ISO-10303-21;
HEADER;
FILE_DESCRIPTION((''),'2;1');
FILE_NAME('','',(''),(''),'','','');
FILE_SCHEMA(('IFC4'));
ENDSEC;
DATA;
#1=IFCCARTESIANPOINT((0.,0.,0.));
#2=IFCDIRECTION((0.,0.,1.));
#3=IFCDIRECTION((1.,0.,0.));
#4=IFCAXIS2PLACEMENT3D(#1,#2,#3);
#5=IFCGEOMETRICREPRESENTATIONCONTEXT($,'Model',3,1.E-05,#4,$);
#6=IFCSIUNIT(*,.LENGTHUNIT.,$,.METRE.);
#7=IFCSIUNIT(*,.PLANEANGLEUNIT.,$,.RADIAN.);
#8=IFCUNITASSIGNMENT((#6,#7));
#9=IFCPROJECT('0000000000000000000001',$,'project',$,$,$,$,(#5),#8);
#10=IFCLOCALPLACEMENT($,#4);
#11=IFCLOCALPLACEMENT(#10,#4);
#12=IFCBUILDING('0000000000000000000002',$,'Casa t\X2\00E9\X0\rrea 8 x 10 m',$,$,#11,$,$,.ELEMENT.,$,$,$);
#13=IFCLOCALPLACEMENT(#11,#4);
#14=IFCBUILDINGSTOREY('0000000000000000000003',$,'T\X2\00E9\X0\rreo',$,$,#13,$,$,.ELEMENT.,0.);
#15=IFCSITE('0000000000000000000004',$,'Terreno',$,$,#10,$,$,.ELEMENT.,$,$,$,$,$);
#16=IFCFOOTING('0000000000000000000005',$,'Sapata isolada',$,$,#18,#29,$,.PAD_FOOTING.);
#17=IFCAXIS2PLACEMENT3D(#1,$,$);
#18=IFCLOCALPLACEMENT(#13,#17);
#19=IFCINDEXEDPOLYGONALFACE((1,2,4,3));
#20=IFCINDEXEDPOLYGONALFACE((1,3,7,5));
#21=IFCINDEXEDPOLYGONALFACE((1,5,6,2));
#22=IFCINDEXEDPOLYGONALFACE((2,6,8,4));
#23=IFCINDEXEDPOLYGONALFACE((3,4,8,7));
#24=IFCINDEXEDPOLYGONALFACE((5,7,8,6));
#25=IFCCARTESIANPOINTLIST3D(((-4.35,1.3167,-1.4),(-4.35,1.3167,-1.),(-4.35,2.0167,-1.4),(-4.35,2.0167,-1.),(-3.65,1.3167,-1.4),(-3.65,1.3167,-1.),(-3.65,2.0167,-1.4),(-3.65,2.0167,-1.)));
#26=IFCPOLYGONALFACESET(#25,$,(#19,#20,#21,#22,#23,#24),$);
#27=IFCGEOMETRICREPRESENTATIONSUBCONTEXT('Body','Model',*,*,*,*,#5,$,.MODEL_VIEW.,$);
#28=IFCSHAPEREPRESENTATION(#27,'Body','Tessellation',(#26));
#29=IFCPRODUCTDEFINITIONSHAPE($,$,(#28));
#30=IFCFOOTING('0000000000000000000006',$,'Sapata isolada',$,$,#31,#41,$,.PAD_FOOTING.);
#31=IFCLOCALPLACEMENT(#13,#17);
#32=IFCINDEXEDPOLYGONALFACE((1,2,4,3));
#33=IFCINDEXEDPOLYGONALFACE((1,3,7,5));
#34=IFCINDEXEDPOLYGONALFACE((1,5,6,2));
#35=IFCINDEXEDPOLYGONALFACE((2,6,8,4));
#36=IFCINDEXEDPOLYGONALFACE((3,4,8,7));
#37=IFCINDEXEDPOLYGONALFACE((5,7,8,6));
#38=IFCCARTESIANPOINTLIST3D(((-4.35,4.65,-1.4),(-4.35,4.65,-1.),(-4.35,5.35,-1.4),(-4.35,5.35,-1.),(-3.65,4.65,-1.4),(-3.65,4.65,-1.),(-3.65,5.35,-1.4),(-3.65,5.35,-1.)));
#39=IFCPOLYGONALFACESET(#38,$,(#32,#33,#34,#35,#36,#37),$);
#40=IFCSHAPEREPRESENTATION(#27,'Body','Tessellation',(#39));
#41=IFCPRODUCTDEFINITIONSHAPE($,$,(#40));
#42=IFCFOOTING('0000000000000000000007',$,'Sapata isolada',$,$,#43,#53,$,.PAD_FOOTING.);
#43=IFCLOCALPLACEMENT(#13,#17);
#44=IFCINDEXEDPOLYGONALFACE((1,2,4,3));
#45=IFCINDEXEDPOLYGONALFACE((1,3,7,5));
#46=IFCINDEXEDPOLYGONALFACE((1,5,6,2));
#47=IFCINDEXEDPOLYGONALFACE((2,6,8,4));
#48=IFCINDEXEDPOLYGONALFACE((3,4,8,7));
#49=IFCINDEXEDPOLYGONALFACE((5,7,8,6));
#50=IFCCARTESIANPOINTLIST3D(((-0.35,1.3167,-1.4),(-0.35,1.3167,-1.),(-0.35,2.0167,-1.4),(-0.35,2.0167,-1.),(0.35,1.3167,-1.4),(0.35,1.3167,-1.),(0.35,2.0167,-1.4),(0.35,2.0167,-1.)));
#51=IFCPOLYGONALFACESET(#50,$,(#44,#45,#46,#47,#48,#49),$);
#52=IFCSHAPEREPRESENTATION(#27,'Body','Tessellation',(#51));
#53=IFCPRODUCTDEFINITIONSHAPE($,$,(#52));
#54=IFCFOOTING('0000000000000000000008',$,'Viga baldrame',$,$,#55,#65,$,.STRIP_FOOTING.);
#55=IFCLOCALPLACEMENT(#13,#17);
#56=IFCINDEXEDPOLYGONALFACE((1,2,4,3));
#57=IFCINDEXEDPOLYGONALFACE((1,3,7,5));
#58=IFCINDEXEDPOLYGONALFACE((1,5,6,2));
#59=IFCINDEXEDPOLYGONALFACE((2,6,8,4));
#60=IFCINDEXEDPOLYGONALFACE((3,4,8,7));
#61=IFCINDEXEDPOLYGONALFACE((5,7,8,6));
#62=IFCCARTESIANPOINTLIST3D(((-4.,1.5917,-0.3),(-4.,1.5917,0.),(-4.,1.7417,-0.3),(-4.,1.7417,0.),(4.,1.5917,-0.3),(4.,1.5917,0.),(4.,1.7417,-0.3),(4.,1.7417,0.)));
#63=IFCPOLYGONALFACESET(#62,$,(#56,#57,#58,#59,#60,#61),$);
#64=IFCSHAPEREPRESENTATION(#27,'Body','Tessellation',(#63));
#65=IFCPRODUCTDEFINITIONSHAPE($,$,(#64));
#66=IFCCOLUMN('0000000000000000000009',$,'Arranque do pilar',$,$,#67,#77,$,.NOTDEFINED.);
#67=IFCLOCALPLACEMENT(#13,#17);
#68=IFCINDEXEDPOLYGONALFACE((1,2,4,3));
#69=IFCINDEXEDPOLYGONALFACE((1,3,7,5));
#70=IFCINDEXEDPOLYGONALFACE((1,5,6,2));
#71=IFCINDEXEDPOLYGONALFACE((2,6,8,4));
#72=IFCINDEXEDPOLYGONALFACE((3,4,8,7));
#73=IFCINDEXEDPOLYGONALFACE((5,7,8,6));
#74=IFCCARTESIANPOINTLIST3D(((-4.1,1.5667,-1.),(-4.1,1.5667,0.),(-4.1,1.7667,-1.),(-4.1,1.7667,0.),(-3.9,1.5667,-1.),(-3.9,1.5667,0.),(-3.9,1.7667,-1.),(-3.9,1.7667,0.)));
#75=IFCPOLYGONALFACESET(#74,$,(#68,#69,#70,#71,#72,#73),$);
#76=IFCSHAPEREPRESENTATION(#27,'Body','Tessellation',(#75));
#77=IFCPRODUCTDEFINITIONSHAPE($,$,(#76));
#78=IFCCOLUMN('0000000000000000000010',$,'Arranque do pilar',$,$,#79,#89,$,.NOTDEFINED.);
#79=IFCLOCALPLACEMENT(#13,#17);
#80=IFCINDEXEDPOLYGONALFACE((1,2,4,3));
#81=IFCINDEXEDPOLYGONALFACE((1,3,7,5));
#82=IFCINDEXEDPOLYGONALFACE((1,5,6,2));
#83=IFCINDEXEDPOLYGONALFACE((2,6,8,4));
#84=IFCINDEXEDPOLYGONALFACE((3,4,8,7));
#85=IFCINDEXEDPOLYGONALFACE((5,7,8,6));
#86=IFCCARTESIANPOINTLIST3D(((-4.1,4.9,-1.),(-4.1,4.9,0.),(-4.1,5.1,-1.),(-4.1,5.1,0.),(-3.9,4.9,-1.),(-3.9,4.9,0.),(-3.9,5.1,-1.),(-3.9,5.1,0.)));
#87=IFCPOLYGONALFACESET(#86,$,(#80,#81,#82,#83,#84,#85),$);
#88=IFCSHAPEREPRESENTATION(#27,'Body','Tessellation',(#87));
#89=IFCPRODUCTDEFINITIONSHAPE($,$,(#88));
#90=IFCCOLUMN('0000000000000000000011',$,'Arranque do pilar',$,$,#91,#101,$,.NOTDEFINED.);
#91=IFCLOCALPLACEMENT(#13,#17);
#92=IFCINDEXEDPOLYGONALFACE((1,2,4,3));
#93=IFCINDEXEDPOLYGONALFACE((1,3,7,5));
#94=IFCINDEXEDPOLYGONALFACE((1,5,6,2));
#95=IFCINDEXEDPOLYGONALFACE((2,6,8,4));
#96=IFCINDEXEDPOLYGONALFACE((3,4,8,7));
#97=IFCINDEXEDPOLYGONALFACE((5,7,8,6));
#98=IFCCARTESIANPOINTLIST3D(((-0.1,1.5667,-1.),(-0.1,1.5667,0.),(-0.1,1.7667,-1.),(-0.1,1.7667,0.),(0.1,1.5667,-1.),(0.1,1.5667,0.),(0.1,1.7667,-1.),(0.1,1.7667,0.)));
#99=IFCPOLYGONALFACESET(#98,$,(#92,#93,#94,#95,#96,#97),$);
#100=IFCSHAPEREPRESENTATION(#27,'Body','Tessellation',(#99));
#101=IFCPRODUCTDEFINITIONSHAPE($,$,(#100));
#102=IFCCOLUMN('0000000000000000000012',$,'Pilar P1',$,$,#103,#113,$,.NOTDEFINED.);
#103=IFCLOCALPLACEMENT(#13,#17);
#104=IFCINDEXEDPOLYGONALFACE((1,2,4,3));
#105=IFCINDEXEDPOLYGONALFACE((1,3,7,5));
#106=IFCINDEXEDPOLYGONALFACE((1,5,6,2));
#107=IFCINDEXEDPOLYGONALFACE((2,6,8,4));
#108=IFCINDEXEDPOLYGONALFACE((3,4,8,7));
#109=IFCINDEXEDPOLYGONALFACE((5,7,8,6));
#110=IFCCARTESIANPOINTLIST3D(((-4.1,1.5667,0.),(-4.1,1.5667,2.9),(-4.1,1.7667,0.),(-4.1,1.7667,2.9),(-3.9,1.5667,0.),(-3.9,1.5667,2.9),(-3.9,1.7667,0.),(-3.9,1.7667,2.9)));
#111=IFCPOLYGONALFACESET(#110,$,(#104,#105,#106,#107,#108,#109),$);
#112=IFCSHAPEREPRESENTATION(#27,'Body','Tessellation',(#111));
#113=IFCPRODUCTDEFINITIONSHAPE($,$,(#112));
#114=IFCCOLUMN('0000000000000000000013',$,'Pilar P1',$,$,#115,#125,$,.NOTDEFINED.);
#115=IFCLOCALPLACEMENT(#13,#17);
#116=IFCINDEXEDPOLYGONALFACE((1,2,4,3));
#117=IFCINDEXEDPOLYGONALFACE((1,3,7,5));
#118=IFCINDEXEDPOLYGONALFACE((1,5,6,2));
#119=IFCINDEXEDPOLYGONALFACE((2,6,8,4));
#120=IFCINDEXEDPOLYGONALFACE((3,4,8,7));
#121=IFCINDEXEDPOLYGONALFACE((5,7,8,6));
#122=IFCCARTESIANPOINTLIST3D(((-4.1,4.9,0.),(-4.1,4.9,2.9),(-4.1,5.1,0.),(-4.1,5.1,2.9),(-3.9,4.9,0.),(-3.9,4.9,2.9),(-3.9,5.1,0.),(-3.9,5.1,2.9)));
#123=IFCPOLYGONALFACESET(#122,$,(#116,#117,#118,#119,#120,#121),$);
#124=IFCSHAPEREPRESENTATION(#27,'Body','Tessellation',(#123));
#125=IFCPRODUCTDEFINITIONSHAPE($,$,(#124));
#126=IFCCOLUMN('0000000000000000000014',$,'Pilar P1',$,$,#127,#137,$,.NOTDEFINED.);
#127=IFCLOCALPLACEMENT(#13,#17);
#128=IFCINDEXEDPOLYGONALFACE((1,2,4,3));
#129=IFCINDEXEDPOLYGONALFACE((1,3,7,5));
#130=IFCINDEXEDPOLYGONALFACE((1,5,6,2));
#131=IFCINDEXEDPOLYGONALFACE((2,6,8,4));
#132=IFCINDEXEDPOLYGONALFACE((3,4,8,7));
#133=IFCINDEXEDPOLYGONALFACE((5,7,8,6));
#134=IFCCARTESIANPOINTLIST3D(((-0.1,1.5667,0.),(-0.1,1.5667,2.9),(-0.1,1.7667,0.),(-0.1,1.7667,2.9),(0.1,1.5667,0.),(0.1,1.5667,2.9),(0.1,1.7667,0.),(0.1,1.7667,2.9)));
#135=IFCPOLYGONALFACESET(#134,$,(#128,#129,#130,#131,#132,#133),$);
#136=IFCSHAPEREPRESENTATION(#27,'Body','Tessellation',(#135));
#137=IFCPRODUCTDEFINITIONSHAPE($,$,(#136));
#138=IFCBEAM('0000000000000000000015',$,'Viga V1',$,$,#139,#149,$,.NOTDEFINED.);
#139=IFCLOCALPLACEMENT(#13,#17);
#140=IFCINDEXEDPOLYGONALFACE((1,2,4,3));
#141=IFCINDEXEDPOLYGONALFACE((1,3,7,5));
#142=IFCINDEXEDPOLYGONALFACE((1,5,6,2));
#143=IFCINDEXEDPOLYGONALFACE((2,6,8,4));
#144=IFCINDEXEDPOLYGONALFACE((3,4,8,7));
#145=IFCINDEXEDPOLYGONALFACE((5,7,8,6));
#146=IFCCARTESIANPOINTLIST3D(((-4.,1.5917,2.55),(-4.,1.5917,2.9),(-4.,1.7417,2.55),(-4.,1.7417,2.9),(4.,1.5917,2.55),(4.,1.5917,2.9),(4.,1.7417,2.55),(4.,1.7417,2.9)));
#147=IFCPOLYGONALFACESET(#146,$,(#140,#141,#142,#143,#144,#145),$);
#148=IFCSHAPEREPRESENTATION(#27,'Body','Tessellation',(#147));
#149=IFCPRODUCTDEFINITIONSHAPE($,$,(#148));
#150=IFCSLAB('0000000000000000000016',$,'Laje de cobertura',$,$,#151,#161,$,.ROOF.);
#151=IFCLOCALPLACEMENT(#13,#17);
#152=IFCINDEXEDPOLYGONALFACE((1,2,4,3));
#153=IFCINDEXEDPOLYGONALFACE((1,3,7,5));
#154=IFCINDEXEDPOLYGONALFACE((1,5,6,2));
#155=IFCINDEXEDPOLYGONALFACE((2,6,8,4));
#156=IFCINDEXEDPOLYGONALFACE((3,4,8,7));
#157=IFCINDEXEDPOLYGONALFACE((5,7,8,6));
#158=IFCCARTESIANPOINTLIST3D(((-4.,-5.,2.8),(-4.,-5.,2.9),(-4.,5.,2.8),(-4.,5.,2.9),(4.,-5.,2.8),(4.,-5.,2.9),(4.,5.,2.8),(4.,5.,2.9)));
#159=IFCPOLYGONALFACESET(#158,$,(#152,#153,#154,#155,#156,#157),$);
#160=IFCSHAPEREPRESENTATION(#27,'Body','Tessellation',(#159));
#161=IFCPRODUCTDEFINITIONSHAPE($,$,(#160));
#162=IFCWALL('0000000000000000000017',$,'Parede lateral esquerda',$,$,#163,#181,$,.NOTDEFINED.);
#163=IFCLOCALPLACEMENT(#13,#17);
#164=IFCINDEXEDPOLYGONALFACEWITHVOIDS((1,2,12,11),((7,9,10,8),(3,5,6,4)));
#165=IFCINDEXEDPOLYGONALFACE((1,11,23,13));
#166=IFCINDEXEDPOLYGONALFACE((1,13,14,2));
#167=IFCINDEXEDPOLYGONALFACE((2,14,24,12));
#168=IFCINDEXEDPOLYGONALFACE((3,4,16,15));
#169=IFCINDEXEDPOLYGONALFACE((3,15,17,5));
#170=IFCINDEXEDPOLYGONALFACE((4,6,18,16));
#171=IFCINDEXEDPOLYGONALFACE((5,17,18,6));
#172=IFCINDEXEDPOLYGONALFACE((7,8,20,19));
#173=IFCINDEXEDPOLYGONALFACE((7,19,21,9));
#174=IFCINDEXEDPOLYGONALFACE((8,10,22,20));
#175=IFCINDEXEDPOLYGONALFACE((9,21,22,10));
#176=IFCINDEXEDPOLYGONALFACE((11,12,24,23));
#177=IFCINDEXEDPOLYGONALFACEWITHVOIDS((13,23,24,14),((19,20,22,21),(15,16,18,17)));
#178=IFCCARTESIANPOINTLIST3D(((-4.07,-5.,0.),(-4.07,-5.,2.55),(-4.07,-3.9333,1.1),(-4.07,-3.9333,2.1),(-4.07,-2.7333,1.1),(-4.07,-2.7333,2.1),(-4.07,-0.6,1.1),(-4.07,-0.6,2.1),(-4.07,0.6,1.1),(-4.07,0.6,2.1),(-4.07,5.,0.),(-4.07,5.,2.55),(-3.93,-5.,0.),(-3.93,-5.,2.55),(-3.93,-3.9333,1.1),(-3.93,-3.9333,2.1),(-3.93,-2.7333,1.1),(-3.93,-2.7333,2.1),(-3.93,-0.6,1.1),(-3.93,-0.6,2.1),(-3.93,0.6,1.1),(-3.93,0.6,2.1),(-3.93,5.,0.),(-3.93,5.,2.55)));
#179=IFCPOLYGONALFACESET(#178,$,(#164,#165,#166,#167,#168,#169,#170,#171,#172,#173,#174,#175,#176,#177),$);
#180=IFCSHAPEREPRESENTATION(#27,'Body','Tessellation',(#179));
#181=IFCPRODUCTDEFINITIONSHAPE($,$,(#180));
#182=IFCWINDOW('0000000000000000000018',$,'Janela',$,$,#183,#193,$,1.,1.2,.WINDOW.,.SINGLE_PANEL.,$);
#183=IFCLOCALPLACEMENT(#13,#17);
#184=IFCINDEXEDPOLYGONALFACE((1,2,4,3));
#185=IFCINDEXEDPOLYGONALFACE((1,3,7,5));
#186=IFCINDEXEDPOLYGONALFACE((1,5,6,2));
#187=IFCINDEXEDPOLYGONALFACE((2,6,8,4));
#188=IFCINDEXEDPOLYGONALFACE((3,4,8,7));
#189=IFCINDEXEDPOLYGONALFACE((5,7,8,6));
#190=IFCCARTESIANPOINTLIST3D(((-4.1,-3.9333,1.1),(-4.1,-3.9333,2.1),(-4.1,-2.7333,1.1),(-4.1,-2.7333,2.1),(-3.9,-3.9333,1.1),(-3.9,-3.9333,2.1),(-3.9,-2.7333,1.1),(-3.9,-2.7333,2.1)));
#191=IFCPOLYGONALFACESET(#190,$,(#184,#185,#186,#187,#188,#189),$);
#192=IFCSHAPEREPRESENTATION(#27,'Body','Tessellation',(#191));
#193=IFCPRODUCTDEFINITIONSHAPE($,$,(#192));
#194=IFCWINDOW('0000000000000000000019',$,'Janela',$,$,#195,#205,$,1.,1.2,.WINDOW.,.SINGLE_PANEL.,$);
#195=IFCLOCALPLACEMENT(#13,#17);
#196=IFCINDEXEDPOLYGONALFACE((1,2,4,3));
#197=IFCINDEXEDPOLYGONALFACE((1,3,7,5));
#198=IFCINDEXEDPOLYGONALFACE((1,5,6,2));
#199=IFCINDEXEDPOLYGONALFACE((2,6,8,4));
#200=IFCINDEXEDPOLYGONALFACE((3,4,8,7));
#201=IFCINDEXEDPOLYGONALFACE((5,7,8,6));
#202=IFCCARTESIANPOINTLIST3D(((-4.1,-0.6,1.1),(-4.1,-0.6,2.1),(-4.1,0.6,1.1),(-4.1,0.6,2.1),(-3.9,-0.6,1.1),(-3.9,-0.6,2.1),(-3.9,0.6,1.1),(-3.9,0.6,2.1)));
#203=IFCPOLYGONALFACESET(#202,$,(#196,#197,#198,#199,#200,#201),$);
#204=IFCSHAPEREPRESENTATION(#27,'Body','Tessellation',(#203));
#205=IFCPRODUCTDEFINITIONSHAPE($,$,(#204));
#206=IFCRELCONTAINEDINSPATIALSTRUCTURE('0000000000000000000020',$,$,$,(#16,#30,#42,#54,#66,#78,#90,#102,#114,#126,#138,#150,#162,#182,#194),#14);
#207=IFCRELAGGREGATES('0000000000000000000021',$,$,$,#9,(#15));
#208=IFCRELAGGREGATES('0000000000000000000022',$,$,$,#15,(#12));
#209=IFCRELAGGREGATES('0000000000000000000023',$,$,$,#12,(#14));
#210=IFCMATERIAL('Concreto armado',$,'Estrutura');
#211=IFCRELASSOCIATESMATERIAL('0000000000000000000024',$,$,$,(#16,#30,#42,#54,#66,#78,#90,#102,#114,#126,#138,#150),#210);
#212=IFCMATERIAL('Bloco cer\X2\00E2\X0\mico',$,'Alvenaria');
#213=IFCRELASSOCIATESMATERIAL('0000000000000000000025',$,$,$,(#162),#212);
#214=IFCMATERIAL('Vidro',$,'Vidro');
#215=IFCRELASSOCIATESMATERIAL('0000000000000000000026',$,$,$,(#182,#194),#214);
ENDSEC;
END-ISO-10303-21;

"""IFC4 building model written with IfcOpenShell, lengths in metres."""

from ifc_helpers import new_model, si_unit, frame, origin_with_axes, origin_2d, place, context, subcontext, project, spatial, rectangle, extrude, material, element, fill, save


model = new_model("IFC4")

# Units and contexts
model_context = context("Model", 3, precision=1e-05, world=origin_with_axes())
body_context = subcontext(model_context, "Body", "Model", "MODEL_VIEW")
ifc_project = project(units=[si_unit("LENGTHUNIT", "METRE"), si_unit("PLANEANGLEUNIT", "RADIAN")], contexts=[model_context])

# Site, building, storey
site_placement = place(None, origin_with_axes())
site = spatial("IfcSite", under=ifc_project, at=site_placement, Name="Terreno", CompositionType="ELEMENT")
building_placement = place(site_placement, origin_with_axes())
building = spatial("IfcBuilding", under=site, at=building_placement, Name="Casa térrea 8 x 10 m", CompositionType="ELEMENT")
storey_placement = place(building_placement, origin_with_axes())
storey = spatial("IfcBuildingStorey", under=building, at=storey_placement, Name="Térreo", CompositionType="ELEMENT", Elevation=0.0)

# Footings
ifc_material_1 = material(Name="Concreto armado", Category="Estrutura")
for number, where, z_axis, x_axis, name in (
    (1, (-4.0, 1.6667, -1.4), (0.0, 0.0, 1.0), (1.0, 0.0, 0.0), "Sapata isolada"),
    (2, (-4.0, 5.0, -1.4), (0.0, 0.0, 1.0), (1.0, 0.0, 0.0), "Sapata isolada"),
    (3, (0.0, 1.6667, -1.4), (0.0, 0.0, 1.0), (1.0, 0.0, 0.0), "Sapata isolada"),
):
    element("IfcFooting", number, at=place(storey_placement, frame(where, z_axis=z_axis, x_axis=x_axis)), inside=storey, material=ifc_material_1, Name=name, PredefinedType="PAD_FOOTING", context=body_context, shape_type="SweptSolid", body=[
        extrude(rectangle(XDim=0.7, YDim=0.7, at=origin_2d()), None, (0.0, 0.0, 1.0), 0.4),
    ])
footing_placement = place(storey_placement, frame((0.0, 1.6667, -0.3), z_axis=(0.0, 0.0, 1.0), x_axis=(1.0, 0.0, 0.0)))
element("IfcFooting", 4, at=footing_placement, inside=storey, material=ifc_material_1, Name="Viga baldrame", PredefinedType="STRIP_FOOTING", context=body_context, shape_type="SweptSolid", body=[
    extrude(rectangle(XDim=8.0, YDim=0.15, at=origin_2d()), None, (0.0, 0.0, 1.0), 0.3),
])

# Columns
for number, where, z_axis, x_axis, name in (
    (5, (-4.0, 1.6667, -1.0), (0.0, 0.0, 1.0), (1.0, 0.0, 0.0), "Arranque do pilar"),
    (6, (-4.0, 5.0, -1.0), (0.0, 0.0, 1.0), (1.0, 0.0, 0.0), "Arranque do pilar"),
    (7, (0.0, 1.6667, -1.0), (0.0, 0.0, 1.0), (1.0, 0.0, 0.0), "Arranque do pilar"),
):
    element("IfcColumn", number, at=place(storey_placement, frame(where, z_axis=z_axis, x_axis=x_axis)), inside=storey, material=ifc_material_1, Name=name, PredefinedType="NOTDEFINED", context=body_context, shape_type="SweptSolid", body=[
        extrude(rectangle(XDim=0.2, YDim=0.2, at=origin_2d()), None, (0.0, 0.0, 1.0), 1.0),
    ])
for number, where, z_axis, x_axis, name in (
    (8, (-4.0, 1.6667, 0.0), (0.0, 0.0, 1.0), (1.0, 0.0, 0.0), "Pilar P1"),
    (9, (-4.0, 5.0, 0.0), (0.0, 0.0, 1.0), (1.0, 0.0, 0.0), "Pilar P1"),
    (10, (0.0, 1.6667, 0.0), (0.0, 0.0, 1.0), (1.0, 0.0, 0.0), "Pilar P1"),
):
    element("IfcColumn", number, at=place(storey_placement, frame(where, z_axis=z_axis, x_axis=x_axis)), inside=storey, material=ifc_material_1, Name=name, PredefinedType="NOTDEFINED", context=body_context, shape_type="SweptSolid", body=[
        extrude(rectangle(XDim=0.2, YDim=0.2, at=origin_2d()), None, (0.0, 0.0, 1.0), 2.9),
    ])

# Beam
beam_placement = place(storey_placement, frame((0.0, 1.6667, 2.55), z_axis=(0.0, 0.0, 1.0), x_axis=(1.0, 0.0, 0.0)))
element("IfcBeam", 11, at=beam_placement, inside=storey, material=ifc_material_1, Name="Viga V1", PredefinedType="NOTDEFINED", context=body_context, shape_type="SweptSolid", body=[
    extrude(rectangle(XDim=8.0, YDim=0.15, at=origin_2d()), None, (0.0, 0.0, 1.0), 0.35),
])

# Slab
slab_placement = place(storey_placement, frame((0.0, 0.0, 2.8), z_axis=(0.0, 0.0, 1.0), x_axis=(1.0, 0.0, 0.0)))
element("IfcSlab", 12, at=slab_placement, inside=storey, material=ifc_material_1, Name="Laje de cobertura", PredefinedType="ROOF", context=body_context, shape_type="SweptSolid", body=[
    extrude(rectangle(XDim=8.0, YDim=10.0, at=origin_2d()), None, (0.0, 0.0, 1.0), 0.1),
])

# Wall, openings, windows
ifc_material_2 = material(Name="Bloco cerâmico", Category="Alvenaria")
wall_1_placement = place(storey_placement, frame((-4.0, 0.0, 0.0), z_axis=(0.0, 0.0, 1.0), x_axis=(1.0, 0.0, 0.0)))
wall_1 = element("IfcWall", 13, at=wall_1_placement, inside=storey, material=ifc_material_2, Name="Parede lateral esquerda", PredefinedType="NOTDEFINED", context=body_context, shape_type="SweptSolid", body=[
    extrude(rectangle(XDim=0.14, YDim=10.0, at=origin_2d()), None, (0.0, 0.0, 1.0), 2.55),
])
opening_1_placement = place(storey_placement, frame((-4.0, -3.3333, 1.1), z_axis=(0.0, 0.0, 1.0), x_axis=(1.0, 0.0, 0.0)))
opening_1 = element("IfcOpeningElement", 14, at=opening_1_placement, cuts=wall_1, PredefinedType="OPENING", context=body_context, shape_type="SweptSolid", body=[
    extrude(rectangle(XDim=0.4, YDim=1.2, at=origin_2d()), None, (0.0, 0.0, 1.0), 1.0),
])
opening_2_placement = place(storey_placement, frame((-4.0, 0.0, 1.1), z_axis=(0.0, 0.0, 1.0), x_axis=(1.0, 0.0, 0.0)))
opening_2 = element("IfcOpeningElement", 15, at=opening_2_placement, cuts=wall_1, PredefinedType="OPENING", context=body_context, shape_type="SweptSolid", body=[
    extrude(rectangle(XDim=0.4, YDim=1.2, at=origin_2d()), None, (0.0, 0.0, 1.0), 1.0),
])
ifc_material_3 = material(Name="Vidro", Category="Vidro")
window_1_placement = place(storey_placement, frame((-4.0, -3.3333, 1.1), z_axis=(0.0, 0.0, 1.0), x_axis=(1.0, 0.0, 0.0)))
window_1 = element("IfcWindow", 16, at=window_1_placement, inside=storey, material=ifc_material_3, Name="Janela", OverallHeight=1.0, OverallWidth=1.2, PartitioningType="SINGLE_PANEL", PredefinedType="WINDOW", context=body_context, shape_type="SweptSolid", body=[
    extrude(rectangle(XDim=0.2, YDim=1.2, at=origin_2d()), None, (0.0, 0.0, 1.0), 1.0),
])
fill(opening_1, window_1)
window_2_placement = place(storey_placement, frame((-4.0, 0.0, 1.1), z_axis=(0.0, 0.0, 1.0), x_axis=(1.0, 0.0, 0.0)))
window_2 = element("IfcWindow", 17, at=window_2_placement, inside=storey, material=ifc_material_3, Name="Janela", OverallHeight=1.0, OverallWidth=1.2, PartitioningType="SINGLE_PANEL", PredefinedType="WINDOW", context=body_context, shape_type="SweptSolid", body=[
    extrude(rectangle(XDim=0.2, YDim=1.2, at=origin_2d()), None, (0.0, 0.0, 1.0), 1.0),
])
fill(opening_2, window_2)

save(model, "model.ifc")
